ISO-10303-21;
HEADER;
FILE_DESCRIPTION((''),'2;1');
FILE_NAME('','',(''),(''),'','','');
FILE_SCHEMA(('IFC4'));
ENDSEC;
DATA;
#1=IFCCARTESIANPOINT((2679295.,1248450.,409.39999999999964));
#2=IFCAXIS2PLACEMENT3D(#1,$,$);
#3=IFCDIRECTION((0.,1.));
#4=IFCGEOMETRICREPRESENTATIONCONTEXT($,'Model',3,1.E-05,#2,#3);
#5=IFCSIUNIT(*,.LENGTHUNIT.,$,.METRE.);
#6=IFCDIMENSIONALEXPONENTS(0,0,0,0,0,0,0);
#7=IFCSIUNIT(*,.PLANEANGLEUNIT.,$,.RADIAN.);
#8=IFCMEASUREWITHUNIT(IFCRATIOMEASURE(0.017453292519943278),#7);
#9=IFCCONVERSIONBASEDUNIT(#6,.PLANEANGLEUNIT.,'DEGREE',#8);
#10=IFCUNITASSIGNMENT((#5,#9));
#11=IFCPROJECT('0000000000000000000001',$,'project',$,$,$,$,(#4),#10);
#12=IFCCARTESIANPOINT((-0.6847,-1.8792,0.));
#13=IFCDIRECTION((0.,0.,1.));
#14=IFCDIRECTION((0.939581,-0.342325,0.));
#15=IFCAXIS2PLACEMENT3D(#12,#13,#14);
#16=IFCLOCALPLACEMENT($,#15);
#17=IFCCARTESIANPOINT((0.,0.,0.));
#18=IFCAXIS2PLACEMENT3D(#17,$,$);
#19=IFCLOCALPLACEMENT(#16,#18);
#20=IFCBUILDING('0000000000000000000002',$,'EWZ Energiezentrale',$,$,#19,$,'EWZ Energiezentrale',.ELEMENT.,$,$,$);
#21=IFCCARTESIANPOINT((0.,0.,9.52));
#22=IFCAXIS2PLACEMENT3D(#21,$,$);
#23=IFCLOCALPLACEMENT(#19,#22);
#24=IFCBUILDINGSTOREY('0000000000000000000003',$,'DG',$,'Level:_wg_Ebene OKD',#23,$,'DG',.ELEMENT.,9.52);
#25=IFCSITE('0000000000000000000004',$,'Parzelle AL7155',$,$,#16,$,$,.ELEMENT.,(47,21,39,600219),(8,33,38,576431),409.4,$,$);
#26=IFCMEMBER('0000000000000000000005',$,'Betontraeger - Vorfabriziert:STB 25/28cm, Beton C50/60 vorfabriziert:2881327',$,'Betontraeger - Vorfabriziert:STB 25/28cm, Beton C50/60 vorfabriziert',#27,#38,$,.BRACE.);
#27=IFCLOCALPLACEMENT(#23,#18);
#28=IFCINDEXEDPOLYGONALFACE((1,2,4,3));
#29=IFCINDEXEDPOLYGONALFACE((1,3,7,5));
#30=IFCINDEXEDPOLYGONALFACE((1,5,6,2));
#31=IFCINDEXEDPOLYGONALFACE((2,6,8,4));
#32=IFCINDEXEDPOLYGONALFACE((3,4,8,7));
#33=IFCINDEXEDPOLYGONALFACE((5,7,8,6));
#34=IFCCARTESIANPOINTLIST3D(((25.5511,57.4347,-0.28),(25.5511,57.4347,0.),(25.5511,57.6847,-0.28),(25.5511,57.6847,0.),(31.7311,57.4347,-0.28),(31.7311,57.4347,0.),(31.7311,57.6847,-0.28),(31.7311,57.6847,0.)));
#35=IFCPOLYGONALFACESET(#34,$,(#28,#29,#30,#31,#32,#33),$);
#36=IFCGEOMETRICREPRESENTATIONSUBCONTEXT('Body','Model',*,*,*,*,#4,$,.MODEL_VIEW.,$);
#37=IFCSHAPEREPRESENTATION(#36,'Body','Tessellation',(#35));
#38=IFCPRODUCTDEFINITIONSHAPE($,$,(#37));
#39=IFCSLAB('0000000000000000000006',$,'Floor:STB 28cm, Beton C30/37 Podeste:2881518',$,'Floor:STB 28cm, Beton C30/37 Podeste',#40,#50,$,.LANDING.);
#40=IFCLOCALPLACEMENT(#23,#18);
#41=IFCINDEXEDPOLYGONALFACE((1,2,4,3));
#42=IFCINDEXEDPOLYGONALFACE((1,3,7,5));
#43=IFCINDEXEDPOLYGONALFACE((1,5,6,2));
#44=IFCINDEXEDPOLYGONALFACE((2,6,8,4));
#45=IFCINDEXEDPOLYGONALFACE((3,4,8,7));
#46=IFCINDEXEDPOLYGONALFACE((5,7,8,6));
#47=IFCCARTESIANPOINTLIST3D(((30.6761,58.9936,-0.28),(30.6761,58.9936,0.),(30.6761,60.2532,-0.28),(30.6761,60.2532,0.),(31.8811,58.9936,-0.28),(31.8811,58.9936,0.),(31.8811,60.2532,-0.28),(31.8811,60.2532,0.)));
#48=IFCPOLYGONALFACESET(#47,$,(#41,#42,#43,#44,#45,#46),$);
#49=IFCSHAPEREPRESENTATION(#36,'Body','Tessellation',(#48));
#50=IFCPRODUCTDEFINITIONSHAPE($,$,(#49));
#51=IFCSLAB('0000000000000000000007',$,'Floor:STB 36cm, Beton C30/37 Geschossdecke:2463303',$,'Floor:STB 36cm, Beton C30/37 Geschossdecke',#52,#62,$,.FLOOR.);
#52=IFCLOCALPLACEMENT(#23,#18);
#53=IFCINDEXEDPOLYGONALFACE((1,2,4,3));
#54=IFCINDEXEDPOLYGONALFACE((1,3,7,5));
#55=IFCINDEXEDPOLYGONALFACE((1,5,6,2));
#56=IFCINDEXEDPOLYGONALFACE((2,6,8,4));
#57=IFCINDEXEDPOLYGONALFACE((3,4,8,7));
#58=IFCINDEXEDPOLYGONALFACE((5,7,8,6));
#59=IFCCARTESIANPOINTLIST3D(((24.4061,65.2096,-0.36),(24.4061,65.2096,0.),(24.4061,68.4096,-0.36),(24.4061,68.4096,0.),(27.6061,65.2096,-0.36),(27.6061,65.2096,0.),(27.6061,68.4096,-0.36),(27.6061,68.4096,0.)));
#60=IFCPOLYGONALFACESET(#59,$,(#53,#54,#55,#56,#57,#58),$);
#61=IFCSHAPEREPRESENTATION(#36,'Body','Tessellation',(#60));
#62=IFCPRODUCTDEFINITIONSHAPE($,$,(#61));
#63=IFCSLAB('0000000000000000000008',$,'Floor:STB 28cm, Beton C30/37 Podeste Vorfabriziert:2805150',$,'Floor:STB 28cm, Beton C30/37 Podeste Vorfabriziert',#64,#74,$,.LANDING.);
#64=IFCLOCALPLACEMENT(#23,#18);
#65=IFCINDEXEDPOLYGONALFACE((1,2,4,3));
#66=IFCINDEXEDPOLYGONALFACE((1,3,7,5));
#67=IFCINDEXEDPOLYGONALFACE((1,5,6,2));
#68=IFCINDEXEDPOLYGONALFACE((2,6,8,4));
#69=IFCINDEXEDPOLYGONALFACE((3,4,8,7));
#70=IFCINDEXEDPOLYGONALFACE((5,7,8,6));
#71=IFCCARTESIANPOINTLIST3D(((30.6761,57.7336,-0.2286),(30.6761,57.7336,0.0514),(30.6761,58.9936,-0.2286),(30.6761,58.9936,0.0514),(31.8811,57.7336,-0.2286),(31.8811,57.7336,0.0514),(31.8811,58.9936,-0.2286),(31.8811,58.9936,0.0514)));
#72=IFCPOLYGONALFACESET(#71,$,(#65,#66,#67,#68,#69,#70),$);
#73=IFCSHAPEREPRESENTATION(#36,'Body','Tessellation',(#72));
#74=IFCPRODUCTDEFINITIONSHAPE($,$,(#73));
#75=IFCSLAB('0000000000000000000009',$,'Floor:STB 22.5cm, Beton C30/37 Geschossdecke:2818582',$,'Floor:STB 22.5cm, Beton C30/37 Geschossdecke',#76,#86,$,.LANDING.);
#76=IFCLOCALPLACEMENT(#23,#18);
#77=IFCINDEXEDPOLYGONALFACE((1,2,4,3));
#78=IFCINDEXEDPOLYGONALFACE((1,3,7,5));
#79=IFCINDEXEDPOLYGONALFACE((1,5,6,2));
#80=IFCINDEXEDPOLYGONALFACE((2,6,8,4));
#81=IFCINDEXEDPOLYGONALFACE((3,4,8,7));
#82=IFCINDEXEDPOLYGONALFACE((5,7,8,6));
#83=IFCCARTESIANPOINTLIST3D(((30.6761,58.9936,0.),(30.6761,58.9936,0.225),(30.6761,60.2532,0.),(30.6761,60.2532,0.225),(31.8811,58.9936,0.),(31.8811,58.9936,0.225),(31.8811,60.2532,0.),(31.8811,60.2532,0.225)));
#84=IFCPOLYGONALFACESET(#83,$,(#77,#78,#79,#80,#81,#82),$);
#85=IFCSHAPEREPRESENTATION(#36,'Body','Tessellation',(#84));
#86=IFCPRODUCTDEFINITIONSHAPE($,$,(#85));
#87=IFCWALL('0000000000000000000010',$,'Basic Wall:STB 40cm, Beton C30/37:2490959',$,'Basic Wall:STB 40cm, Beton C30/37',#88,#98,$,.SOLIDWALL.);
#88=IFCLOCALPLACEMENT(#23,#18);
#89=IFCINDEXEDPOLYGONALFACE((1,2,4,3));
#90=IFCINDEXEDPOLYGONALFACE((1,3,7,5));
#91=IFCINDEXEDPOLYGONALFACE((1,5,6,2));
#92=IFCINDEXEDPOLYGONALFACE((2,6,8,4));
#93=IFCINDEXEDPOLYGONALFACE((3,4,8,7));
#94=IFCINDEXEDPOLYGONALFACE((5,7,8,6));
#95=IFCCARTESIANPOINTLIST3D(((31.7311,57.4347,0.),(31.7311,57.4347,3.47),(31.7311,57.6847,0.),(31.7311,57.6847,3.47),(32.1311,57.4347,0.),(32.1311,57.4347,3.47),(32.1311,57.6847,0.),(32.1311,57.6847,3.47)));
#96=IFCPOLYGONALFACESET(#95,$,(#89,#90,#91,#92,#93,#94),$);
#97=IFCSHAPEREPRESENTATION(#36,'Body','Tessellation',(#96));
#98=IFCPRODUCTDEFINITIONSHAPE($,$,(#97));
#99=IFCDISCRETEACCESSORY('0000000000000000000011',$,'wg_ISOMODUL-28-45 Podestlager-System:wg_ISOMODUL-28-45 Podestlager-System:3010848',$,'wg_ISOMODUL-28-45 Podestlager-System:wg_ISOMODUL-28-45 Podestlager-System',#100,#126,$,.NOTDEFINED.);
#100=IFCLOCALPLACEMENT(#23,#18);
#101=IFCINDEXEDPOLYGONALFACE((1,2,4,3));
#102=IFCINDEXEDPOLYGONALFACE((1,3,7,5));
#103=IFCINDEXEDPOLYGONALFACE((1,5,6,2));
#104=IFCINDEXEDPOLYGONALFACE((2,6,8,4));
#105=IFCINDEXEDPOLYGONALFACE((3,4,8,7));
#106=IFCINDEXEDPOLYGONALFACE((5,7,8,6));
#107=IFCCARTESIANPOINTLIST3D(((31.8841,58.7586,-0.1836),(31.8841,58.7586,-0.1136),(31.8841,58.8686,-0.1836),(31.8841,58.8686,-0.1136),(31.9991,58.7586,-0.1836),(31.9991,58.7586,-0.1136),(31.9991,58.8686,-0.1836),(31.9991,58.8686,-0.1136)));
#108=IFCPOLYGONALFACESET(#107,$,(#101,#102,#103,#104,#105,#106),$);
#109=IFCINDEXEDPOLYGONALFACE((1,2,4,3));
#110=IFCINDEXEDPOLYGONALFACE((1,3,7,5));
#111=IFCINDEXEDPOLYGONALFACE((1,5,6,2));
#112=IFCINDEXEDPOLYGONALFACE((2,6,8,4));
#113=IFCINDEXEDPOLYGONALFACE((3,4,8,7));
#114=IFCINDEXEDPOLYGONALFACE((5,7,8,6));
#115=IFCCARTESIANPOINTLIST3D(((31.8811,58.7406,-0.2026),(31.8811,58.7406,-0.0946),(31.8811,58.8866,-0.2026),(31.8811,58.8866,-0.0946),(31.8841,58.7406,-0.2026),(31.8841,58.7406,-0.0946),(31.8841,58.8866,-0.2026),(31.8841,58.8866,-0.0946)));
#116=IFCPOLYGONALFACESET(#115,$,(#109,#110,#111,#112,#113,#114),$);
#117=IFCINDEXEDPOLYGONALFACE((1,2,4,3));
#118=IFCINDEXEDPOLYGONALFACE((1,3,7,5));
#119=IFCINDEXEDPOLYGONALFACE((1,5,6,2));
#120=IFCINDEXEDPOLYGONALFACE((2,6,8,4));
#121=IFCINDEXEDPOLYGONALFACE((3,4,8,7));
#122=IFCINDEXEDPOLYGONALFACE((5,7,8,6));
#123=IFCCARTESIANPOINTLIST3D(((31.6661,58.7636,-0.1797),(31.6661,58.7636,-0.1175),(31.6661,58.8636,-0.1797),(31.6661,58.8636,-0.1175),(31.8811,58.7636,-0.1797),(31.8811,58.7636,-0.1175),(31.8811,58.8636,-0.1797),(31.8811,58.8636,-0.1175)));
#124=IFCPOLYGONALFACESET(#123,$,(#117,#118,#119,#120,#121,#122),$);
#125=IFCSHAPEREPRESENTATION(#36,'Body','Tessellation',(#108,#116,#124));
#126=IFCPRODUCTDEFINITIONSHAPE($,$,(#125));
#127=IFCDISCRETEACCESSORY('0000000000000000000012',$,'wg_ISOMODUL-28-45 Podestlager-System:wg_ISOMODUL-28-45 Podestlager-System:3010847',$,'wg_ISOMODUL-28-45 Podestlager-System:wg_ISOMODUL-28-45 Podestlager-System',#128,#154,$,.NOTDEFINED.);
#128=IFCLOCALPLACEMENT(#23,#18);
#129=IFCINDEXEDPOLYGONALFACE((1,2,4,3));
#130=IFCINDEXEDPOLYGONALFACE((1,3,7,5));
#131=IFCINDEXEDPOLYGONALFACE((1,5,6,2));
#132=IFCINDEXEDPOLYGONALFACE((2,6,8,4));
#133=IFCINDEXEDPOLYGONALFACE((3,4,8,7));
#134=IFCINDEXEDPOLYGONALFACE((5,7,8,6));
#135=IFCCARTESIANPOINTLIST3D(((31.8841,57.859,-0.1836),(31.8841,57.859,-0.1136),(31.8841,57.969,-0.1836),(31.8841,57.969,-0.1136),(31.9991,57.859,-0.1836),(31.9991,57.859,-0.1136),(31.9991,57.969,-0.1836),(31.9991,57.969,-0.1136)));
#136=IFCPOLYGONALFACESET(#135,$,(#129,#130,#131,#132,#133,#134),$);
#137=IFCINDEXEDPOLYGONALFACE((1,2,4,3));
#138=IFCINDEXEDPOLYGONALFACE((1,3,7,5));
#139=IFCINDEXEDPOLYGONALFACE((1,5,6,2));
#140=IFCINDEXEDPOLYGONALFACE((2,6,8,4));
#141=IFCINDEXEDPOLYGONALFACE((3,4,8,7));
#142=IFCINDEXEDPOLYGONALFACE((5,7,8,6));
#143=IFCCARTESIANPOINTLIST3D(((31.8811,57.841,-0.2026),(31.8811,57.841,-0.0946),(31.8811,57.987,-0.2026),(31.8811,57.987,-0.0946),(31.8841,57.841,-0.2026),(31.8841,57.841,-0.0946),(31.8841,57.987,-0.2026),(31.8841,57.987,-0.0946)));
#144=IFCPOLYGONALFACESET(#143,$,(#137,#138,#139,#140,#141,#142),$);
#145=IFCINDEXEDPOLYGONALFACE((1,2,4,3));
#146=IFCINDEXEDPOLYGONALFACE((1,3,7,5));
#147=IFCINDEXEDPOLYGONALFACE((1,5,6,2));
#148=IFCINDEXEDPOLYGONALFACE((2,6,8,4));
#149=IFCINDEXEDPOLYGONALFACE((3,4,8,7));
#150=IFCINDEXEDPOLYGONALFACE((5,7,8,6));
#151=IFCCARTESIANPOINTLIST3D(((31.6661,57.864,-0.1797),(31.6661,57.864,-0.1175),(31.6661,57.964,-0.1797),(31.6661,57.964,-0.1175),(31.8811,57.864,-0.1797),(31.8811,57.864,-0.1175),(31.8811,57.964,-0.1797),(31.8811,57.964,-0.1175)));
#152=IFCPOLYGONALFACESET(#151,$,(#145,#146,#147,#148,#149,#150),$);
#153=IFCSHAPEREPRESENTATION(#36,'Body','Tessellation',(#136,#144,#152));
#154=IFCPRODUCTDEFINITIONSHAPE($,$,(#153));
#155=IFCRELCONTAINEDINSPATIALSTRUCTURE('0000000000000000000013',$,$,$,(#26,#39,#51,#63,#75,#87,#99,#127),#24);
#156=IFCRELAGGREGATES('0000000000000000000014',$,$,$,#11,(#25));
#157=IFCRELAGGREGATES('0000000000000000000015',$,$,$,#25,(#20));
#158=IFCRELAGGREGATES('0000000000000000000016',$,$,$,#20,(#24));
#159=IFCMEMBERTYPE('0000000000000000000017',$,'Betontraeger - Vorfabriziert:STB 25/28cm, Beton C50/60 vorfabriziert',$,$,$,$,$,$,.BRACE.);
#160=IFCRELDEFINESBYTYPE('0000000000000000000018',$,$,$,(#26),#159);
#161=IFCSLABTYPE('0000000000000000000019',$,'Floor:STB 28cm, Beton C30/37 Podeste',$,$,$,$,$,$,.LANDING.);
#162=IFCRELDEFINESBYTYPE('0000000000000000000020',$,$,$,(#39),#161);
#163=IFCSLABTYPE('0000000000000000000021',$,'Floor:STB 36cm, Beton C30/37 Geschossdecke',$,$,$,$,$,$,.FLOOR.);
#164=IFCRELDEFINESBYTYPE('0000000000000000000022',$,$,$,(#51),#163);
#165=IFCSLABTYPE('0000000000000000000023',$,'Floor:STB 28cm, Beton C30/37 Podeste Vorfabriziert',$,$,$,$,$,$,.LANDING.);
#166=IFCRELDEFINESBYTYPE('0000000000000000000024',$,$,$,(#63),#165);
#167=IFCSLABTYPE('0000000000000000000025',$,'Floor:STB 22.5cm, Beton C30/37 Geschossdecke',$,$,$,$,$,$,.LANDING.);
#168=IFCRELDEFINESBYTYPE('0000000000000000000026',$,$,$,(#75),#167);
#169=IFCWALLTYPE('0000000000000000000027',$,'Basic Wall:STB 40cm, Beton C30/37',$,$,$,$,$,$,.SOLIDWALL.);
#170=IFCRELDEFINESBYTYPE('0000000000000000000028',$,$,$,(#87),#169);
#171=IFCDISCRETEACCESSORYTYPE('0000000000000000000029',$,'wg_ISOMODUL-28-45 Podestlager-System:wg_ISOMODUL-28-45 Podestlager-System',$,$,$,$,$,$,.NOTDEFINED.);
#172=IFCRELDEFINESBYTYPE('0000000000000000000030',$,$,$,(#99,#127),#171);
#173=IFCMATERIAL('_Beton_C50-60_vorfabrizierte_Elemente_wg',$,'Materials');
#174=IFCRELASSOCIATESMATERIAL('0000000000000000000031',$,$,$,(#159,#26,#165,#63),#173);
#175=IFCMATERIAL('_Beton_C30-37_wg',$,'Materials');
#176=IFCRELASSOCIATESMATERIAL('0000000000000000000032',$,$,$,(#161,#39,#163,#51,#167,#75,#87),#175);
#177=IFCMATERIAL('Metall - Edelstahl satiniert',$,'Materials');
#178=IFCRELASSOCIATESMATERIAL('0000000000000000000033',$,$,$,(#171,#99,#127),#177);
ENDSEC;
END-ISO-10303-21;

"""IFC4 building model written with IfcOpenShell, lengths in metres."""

from ifc_helpers import new_model, entity, si_unit, converted_unit, direction, frame, origin, place, context, subcontext, project, spatial, indexed_curve, outline, extrude, source, transform, mapped, material, type_object, type_shapes, element, save


model = new_model("IFC4")

# Units and contexts
model_context = context("Model", 3, precision=1e-05, world=frame((2679295.0, 1248450.0, 409.39999999999964)), true_north=direction((0.0, 1.0)))
body_context = subcontext(model_context, "Body", "Model", "MODEL_VIEW")
ifc_project = project(units=[si_unit("LENGTHUNIT", "METRE"), converted_unit("PLANEANGLEUNIT", "DEGREE", entity("IfcRatioMeasure", 0.017453292519943278), si_unit("PLANEANGLEUNIT", "RADIAN"), dimensions=[0, 0, 0, 0, 0, 0, 0])], contexts=[model_context])

# Site, building, storey
site_placement = place(None, frame((-0.6847, -1.8792, 0.0), z_axis=(0.0, 0.0, 1.0), x_axis=(0.939581, -0.342325, 0.0)))
site = spatial("IfcSite", under=ifc_project, at=site_placement, Name="Parzelle AL7155", CompositionType="ELEMENT", RefLatitude=(47, 21, 39, 600219), RefLongitude=(8, 33, 38, 576431), RefElevation=409.4)
building_placement = place(site_placement, origin())
building = spatial("IfcBuilding", under=site, at=building_placement, Name="EWZ Energiezentrale", LongName="EWZ Energiezentrale", CompositionType="ELEMENT")
storey_placement = place(building_placement, frame((0.0, 0.0, 9.52)))
storey = spatial("IfcBuildingStorey", under=building, at=storey_placement, Name="DG", ObjectType="Level:_wg_Ebene OKD", LongName="DG", CompositionType="ELEMENT", Elevation=9.52)

# Member
ifc_material_1 = material(Name="_Beton_C50-60_vorfabrizierte_Elemente_wg", Category="Materials")
member_type = type_object("IfcMemberType", Name="Betontraeger - Vorfabriziert:STB 25/28cm, Beton C50/60 vorfabriziert", PredefinedType="BRACE", material=ifc_material_1)
shared_shape_1 = source(origin(), body_context, "Body", "SweptSolid", [
    extrude(outline(indexed_curve([(-0.14, -0.125), (0.14, -0.125), (0.14, 0.125), (-0.14, 0.125), (-0.14, -0.125)], self_intersect=False)), frame((25.5511, 57.5597, 9.38), z_axis=(1.0, 0.0, 0.0), x_axis=(0.0, 0.0, -1.0)), (0.0, 0.0, 1.0), 6.1799),
])
member_placement = place(storey_placement, frame((0.0, 0.0, -9.52), z_axis=(0.0, 0.0, 1.0), x_axis=(1.0, 0.0, 0.0)))
element("IfcMember", 1, at=member_placement, inside=storey, type_object=member_type, material=ifc_material_1, Name="Betontraeger - Vorfabriziert:STB 25/28cm, Beton C50/60 vorfabriziert:2881327", ObjectType="Betontraeger - Vorfabriziert:STB 25/28cm, Beton C50/60 vorfabriziert", PredefinedType="BRACE", context=body_context, shape_type="MappedRepresentation", body=[
    mapped(shared_shape_1, transform((0.0, 0.0, 0.0), scale=1.0)),
])

# Shared definitions
ifc_material_2 = material(Name="_Beton_C30-37_wg", Category="Materials")

# Slab
slab_type_1 = type_object("IfcSlabType", Name="Floor:STB 28cm, Beton C30/37 Podeste", PredefinedType="LANDING", material=ifc_material_2)
slab_1_placement = place(storey_placement, origin())
element("IfcSlab", 2, at=slab_1_placement, inside=storey, type_object=slab_type_1, material=ifc_material_2, Name="Floor:STB 28cm, Beton C30/37 Podeste:2881518", ObjectType="Floor:STB 28cm, Beton C30/37 Podeste", PredefinedType="LANDING", context=body_context, shape_type="SweptSolid", body=[
    extrude(outline(indexed_curve([(-0.6298, -0.6025), (0.6298, -0.6025), (0.6298, 0.6025), (-0.6298, 0.6025), (-0.6298, -0.6025)], self_intersect=False)), frame((31.2786, 59.6234, 0.0), z_axis=(0.0, 0.0, -1.0), x_axis=(0.0, 1.0, 0.0)), (0.0, 0.0, 1.0), 0.28),
])

# Slab
slab_type_2 = type_object("IfcSlabType", Name="Floor:STB 36cm, Beton C30/37 Geschossdecke", PredefinedType="FLOOR", material=ifc_material_2)
slab_2_placement = place(storey_placement, origin())
element("IfcSlab", 3, at=slab_2_placement, inside=storey, type_object=slab_type_2, material=ifc_material_2, Name="Floor:STB 36cm, Beton C30/37 Geschossdecke:2463303", ObjectType="Floor:STB 36cm, Beton C30/37 Geschossdecke", PredefinedType="FLOOR", context=body_context, shape_type="SweptSolid", body=[
    extrude(outline(indexed_curve([(-1.6, -1.6), (1.6, -1.6), (1.6, 1.6), (-1.6, 1.6), (-1.6, -1.6)], self_intersect=False)), frame((26.0061, 66.8096, 0.0), z_axis=(0.0, 0.0, -1.0), x_axis=(0.0, 1.0, 0.0)), (0.0, 0.0, 1.0), 0.36),
])

# Slabs
slab_type_3 = type_object("IfcSlabType", Name="Floor:STB 28cm, Beton C30/37 Podeste Vorfabriziert", PredefinedType="LANDING", material=ifc_material_1)
slab_3_placement = place(storey_placement, origin())
element("IfcSlab", 4, at=slab_3_placement, inside=storey, type_object=slab_type_3, material=ifc_material_1, Name="Floor:STB 28cm, Beton C30/37 Podeste Vorfabriziert:2805150", ObjectType="Floor:STB 28cm, Beton C30/37 Podeste Vorfabriziert", PredefinedType="LANDING", context=body_context, shape_type="SweptSolid", body=[
    extrude(outline(indexed_curve([(-0.63, -0.6025), (0.63, -0.6025), (0.63, 0.6025), (-0.63, 0.6025), (-0.63, -0.6025)], self_intersect=False)), frame((31.2786, 58.3636, 0.0514), z_axis=(0.0, 0.0, -1.0), x_axis=(0.0, 1.0, 0.0)), (0.0, 0.0, 1.0), 0.28),
])
slab_type_4 = type_object("IfcSlabType", Name="Floor:STB 22.5cm, Beton C30/37 Geschossdecke", PredefinedType="LANDING", material=ifc_material_2)
slab_4_placement = place(storey_placement, origin())
element("IfcSlab", 5, at=slab_4_placement, inside=storey, type_object=slab_type_4, material=ifc_material_2, Name="Floor:STB 22.5cm, Beton C30/37 Geschossdecke:2818582", ObjectType="Floor:STB 22.5cm, Beton C30/37 Geschossdecke", PredefinedType="LANDING", context=body_context, shape_type="SweptSolid", body=[
    extrude(outline(indexed_curve([(-0.6298, -0.6025), (0.6298, -0.6025), (0.6298, 0.6025), (-0.6298, 0.6025), (-0.6298, -0.6025)], self_intersect=False)), frame((31.2786, 59.6234, 0.225), z_axis=(0.0, 0.0, -1.0), x_axis=(0.0, 1.0, 0.0)), (0.0, 0.0, 1.0), 0.225),
])

# Wall
wall_type = type_object("IfcWallType", Name="Basic Wall:STB 40cm, Beton C30/37", PredefinedType="SOLIDWALL")
wall_placement = place(storey_placement, frame((31.9311, 57.4347, 0.0), z_axis=(0.0, 0.0, 1.0), x_axis=(0.0, 1.0, 0.0)))
element("IfcWall", 6, at=wall_placement, inside=storey, type_object=wall_type, material=ifc_material_2, Name="Basic Wall:STB 40cm, Beton C30/37:2490959", ObjectType="Basic Wall:STB 40cm, Beton C30/37", PredefinedType="SOLIDWALL", context=body_context, shape_type="SweptSolid", body=[
    extrude(outline(indexed_curve([(0.25, 0.2), (0.0, 0.2), (0.0, -0.2), (0.25, -0.2), (0.25, 0.2)], self_intersect=False)), origin(), (0.0, 0.0, 1.0), 3.47),
])

# Discrete accessories
ifc_material_3 = material(Name="Metall - Edelstahl satiniert", Category="Materials")
discrete_accessory_type = type_object("IfcDiscreteAccessoryType", Name="wg_ISOMODUL-28-45 Podestlager-System:wg_ISOMODUL-28-45 Podestlager-System", PredefinedType="NOTDEFINED", material=ifc_material_3)
shared_shape_2 = source(origin(), body_context, "Body", "SweptSolid", [
    extrude(outline(indexed_curve([(-0.055, -0.0575), (0.055, -0.0575), (0.055, 0.0575), (-0.055, 0.0575), (-0.055, -0.0575)], self_intersect=False)), frame((0.0, -0.0575, 0.0), z_axis=(0.0, 0.0, 1.0), x_axis=(-1.0, 0.0, 0.0)), (0.0, 0.0, 1.0), 0.07),
    extrude(outline(indexed_curve([(-0.073, -0.0015), (0.073, -0.0015), (0.073, 0.0015), (-0.073, 0.0015), (-0.073, -0.0015)], self_intersect=False)), frame((0.0, 0.0015, -0.019), z_axis=(0.0, 0.0, 1.0), x_axis=(-1.0, 0.0, 0.0)), (0.0, 0.0, 1.0), 0.108),
    extrude(outline(indexed_curve([(-0.05, -0.1075), (0.05, -0.1075), (0.05, 0.1075), (-0.05, 0.1075), (-0.05, -0.1075)], self_intersect=False)), frame((0.0, 0.1105, 0.0039), z_axis=(0.0, 0.0, 1.0), x_axis=(-1.0, 0.0, 0.0)), (0.0, 0.0, 1.0), 0.0621),
])
type_shapes(discrete_accessory_type, [shared_shape_2])
discrete_accessory_1_placement = place(storey_placement, frame((31.8841, 58.8136, -0.1836), z_axis=(0.0, 0.0, 1.0), x_axis=(0.0, 1.0, 0.0)))
element("IfcDiscreteAccessory", 7, at=discrete_accessory_1_placement, inside=storey, type_object=discrete_accessory_type, material=ifc_material_3, Name="wg_ISOMODUL-28-45 Podestlager-System:wg_ISOMODUL-28-45 Podestlager-System:3010848", ObjectType="wg_ISOMODUL-28-45 Podestlager-System:wg_ISOMODUL-28-45 Podestlager-System", PredefinedType="NOTDEFINED", context=body_context, shape_type="MappedRepresentation", body=[
    mapped(shared_shape_2, transform((0.0, 0.0, 0.0), scale=1.0)),
])
shared_shape_3 = source(origin(), body_context, "Body", "SweptSolid", [
    extrude(outline(indexed_curve([(-0.0575, -0.055), (0.0575, -0.055), (0.0575, 0.055), (-0.0575, 0.055), (-0.0575, -0.055)], self_intersect=False)), frame((0.0, 0.0575, 0.0), z_axis=(0.0, 0.0, 1.0), x_axis=(0.0, 1.0, 0.0)), (0.0, 0.0, 1.0), 0.07),
    extrude(outline(indexed_curve([(-0.0015, -0.073), (0.0015, -0.073), (0.0015, 0.073), (-0.0015, 0.073), (-0.0015, -0.073)], self_intersect=False)), frame((0.0, -0.0015, -0.019), z_axis=(0.0, 0.0, 1.0), x_axis=(0.0, 1.0, 0.0)), (0.0, 0.0, 1.0), 0.108),
    extrude(outline(indexed_curve([(-0.1075, -0.05), (0.1075, -0.05), (0.1075, 0.05), (-0.1075, 0.05), (-0.1075, -0.05)], self_intersect=False)), frame((0.0, -0.1105, 0.0039), z_axis=(0.0, 0.0, 1.0), x_axis=(0.0, 1.0, 0.0)), (0.0, 0.0, 1.0), 0.0621),
])
discrete_accessory_2_placement = place(storey_placement, frame((31.8841, 57.914, -0.1836), z_axis=(0.0, 0.0, 1.0), x_axis=(0.0, -1.0, 0.0)))
element("IfcDiscreteAccessory", 8, at=discrete_accessory_2_placement, inside=storey, type_object=discrete_accessory_type, material=ifc_material_3, Name="wg_ISOMODUL-28-45 Podestlager-System:wg_ISOMODUL-28-45 Podestlager-System:3010847", ObjectType="wg_ISOMODUL-28-45 Podestlager-System:wg_ISOMODUL-28-45 Podestlager-System", PredefinedType="NOTDEFINED", context=body_context, shape_type="MappedRepresentation", body=[
    mapped(shared_shape_3, transform((0.0, 0.0, 0.0), scale=1.0)),
])

save(model, "model.ifc")
